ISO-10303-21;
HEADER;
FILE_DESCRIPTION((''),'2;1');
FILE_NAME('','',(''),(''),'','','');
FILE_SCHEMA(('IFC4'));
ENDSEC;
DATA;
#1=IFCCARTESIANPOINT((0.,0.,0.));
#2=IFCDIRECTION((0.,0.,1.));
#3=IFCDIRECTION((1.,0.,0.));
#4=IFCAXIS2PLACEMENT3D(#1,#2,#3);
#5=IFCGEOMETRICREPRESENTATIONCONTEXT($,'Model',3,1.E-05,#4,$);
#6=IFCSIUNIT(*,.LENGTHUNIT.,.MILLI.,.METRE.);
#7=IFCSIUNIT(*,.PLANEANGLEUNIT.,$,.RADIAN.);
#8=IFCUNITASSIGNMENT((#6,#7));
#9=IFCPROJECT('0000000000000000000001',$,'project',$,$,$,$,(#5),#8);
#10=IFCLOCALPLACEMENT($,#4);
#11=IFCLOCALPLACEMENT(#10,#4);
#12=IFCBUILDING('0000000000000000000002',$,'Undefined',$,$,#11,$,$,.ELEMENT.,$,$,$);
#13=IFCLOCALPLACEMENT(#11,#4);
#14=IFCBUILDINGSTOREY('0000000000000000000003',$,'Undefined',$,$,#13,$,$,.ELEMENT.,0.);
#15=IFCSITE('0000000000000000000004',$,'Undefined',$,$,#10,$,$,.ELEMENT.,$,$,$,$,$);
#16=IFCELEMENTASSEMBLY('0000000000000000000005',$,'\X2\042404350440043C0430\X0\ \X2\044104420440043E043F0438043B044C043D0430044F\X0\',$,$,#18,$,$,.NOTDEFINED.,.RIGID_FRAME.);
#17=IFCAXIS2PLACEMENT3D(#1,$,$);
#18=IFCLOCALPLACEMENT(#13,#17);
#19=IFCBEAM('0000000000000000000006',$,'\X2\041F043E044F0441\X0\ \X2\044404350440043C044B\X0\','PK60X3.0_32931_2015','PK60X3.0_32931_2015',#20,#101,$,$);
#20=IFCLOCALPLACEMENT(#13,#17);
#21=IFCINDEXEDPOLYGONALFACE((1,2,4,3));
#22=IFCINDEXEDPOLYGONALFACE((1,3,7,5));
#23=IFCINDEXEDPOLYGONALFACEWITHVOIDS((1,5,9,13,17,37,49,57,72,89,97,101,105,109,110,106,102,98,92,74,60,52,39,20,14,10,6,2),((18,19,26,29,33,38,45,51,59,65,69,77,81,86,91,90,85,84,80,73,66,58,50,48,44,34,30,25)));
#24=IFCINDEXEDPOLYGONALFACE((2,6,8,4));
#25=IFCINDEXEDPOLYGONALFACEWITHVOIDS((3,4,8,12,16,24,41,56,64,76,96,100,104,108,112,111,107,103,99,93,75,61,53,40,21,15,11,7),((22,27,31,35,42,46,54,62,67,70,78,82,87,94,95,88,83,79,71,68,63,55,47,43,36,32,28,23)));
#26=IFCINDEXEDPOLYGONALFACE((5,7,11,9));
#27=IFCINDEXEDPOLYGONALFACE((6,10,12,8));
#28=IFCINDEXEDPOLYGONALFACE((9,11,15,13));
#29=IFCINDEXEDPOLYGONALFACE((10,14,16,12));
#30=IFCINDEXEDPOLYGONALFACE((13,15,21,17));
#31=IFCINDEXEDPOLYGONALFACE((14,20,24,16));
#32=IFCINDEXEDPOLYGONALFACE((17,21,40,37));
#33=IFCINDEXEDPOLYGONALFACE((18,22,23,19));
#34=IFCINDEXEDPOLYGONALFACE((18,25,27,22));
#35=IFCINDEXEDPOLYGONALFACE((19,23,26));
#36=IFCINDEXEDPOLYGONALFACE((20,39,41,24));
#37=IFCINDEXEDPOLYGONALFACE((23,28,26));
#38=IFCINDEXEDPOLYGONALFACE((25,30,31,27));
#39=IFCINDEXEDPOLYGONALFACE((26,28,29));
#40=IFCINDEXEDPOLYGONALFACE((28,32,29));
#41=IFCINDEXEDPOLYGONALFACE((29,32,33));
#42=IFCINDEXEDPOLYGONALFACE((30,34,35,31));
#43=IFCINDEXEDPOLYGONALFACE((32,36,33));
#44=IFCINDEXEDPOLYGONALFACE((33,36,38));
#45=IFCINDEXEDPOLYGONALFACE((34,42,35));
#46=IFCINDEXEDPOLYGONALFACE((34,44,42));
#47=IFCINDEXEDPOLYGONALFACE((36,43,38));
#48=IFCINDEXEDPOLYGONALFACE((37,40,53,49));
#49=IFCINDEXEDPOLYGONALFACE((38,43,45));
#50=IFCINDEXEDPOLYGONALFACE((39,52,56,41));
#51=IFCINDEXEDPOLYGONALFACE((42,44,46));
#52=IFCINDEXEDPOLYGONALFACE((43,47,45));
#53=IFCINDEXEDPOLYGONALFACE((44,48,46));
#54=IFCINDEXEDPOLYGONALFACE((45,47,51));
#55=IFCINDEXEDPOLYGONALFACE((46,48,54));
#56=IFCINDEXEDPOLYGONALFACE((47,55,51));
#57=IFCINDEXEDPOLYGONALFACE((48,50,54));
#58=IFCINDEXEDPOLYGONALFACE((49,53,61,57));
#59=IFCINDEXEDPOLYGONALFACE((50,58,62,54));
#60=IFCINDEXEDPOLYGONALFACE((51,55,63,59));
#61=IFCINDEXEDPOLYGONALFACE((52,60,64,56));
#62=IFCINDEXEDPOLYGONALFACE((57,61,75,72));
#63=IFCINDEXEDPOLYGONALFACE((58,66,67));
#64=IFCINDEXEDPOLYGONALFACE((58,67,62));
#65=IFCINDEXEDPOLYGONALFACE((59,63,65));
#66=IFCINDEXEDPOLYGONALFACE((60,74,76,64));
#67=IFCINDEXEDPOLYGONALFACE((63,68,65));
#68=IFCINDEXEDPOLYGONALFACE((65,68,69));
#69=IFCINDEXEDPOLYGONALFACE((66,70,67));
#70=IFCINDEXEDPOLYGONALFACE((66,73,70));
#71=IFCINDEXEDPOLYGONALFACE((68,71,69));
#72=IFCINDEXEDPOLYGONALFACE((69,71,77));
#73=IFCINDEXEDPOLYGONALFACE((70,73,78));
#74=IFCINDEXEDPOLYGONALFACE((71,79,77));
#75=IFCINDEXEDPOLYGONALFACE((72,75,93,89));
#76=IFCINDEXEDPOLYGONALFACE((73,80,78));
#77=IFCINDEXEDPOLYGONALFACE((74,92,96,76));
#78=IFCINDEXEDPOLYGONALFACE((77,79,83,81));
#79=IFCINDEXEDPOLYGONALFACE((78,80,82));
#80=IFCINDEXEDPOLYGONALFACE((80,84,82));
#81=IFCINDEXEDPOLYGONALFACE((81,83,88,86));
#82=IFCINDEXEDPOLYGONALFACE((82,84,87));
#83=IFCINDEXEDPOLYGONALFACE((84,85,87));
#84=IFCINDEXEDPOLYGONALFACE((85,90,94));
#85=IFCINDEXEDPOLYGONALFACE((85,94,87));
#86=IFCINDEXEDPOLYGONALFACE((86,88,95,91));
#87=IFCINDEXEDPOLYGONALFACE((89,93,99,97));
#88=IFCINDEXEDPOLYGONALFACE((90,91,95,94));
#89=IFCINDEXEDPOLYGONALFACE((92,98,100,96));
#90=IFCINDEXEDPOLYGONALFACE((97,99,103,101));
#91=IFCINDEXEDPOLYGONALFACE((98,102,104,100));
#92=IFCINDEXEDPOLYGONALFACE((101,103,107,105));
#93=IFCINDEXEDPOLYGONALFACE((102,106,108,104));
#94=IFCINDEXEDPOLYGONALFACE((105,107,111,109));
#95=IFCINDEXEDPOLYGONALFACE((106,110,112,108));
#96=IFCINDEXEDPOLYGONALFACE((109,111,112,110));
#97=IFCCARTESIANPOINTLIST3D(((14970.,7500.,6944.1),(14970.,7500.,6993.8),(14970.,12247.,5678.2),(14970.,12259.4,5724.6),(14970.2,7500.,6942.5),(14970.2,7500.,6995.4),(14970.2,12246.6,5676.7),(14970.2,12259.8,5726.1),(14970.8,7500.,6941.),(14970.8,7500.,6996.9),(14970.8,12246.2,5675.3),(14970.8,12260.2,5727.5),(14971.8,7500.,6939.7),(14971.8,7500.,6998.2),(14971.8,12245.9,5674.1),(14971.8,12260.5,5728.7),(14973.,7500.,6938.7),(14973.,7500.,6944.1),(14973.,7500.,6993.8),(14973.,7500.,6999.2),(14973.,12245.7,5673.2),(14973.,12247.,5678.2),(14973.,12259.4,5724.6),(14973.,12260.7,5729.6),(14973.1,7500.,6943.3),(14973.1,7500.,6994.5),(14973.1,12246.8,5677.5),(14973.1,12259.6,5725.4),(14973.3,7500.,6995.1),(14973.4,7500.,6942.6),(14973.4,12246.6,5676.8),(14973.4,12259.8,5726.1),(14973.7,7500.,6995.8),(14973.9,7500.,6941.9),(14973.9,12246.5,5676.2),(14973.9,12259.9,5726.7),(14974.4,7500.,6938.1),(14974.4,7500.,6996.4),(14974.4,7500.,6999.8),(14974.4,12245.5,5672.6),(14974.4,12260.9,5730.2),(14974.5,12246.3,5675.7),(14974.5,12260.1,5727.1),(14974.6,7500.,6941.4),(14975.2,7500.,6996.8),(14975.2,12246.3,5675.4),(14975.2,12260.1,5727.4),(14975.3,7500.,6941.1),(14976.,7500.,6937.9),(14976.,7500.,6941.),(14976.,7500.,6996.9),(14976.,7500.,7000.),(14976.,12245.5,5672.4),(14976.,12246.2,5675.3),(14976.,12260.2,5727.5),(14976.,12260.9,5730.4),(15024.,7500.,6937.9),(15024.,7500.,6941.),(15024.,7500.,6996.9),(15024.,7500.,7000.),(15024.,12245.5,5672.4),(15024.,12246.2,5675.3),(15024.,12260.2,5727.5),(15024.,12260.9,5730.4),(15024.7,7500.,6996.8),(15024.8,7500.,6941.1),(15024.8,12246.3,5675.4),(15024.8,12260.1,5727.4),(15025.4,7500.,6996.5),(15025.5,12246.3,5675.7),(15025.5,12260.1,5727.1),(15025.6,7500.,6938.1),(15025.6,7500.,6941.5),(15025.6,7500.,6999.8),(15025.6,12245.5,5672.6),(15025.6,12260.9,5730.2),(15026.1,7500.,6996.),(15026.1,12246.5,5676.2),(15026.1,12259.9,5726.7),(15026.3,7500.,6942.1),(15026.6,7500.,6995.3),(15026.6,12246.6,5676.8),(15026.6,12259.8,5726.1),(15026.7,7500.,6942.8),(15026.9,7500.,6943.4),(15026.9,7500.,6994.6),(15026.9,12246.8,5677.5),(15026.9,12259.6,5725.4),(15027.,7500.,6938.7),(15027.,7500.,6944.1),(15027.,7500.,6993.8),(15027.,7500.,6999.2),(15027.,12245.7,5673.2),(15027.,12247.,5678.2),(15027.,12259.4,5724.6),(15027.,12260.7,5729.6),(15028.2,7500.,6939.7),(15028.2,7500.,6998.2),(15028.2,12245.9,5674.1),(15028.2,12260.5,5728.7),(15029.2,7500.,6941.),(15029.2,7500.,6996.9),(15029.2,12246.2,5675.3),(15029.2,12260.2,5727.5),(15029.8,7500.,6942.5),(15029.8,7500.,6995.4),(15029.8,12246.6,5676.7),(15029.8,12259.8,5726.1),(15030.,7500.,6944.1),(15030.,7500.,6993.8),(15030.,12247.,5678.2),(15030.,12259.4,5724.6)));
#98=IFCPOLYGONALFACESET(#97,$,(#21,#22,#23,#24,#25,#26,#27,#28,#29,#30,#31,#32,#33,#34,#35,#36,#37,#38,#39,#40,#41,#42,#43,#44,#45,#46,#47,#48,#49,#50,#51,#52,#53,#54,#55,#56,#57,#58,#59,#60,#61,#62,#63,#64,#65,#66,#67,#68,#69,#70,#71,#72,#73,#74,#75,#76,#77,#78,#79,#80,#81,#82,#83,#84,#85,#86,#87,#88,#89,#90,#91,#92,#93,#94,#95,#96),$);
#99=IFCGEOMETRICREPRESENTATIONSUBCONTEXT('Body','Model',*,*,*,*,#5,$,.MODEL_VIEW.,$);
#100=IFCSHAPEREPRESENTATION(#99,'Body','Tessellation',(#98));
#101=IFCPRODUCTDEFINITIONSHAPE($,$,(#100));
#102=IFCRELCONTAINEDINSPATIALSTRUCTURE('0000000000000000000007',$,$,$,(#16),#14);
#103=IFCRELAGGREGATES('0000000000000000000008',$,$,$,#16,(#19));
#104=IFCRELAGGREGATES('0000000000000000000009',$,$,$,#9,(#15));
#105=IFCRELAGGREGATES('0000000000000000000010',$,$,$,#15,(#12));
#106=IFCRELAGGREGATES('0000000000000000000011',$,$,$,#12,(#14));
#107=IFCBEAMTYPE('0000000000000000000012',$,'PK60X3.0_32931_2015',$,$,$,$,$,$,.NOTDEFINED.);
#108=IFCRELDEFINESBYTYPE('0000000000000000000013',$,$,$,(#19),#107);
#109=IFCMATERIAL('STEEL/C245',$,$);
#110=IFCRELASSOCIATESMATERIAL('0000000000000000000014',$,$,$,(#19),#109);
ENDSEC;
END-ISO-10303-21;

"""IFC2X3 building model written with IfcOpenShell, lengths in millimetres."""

from ifc_helpers import new_model, si_unit, frame, origin_with_axes, origin_2d_with_axis, place, context, subcontext, project, spatial, hollow_rectangle, extrude, clip, halfspace, material, type_object, element, aggregate, save


model = new_model("IFC2X3")

# Units and contexts
model_context = context("Model", 3, precision=1e-05, world=origin_with_axes())
body_context = subcontext(model_context, "Body", "Model", "MODEL_VIEW")
ifc_project = project(units=[si_unit("LENGTHUNIT", "METRE", prefix="MILLI"), si_unit("PLANEANGLEUNIT", "RADIAN")], contexts=[model_context])

# Site, building, storey
site_placement = place(None, origin_with_axes())
site = spatial("IfcSite", under=ifc_project, at=site_placement, Name="Undefined", CompositionType="ELEMENT")
building_placement = place(site_placement, origin_with_axes())
building = spatial("IfcBuilding", under=site, at=building_placement, Name="Undefined", CompositionType="ELEMENT")
storey_placement = place(building_placement, origin_with_axes())
storey = spatial("IfcBuildingStorey", under=building, at=storey_placement, Name="Undefined", CompositionType="ELEMENT", Elevation=0.0)

# Element assembly
assembly_1_placement = place(storey_placement, origin_with_axes())
assembly_1 = element("IfcElementAssembly", 1, at=assembly_1_placement, inside=storey, Name="Ферма стропильная", AssemblyPlace="NOTDEFINED", PredefinedType="RIGID_FRAME")
ifc_material_1 = material(Name="STEEL/C245")

# Beam
beam_type_1 = type_object("IfcBeamType", Name="PK60X3.0_32931_2015", PredefinedType="NOTDEFINED")
beam_1_placement = place(assembly_1_placement, frame((15000.0, 12253.2, 5701.4), z_axis=(0.0, 0.257663, 0.966235), x_axis=(0.0, -0.966235, 0.257663)))
beam_1 = element("IfcBeam", 2, at=beam_1_placement, type_object=beam_type_1, material=ifc_material_1, Name="Пояс фермы", Description="PK60X3.0_32931_2015", ObjectType="PK60X3.0_32931_2015", context=body_context, shape_type="Clipping", body=[
    clip(extrude(hollow_rectangle(XDim=60.0, YDim=60.0, WallThickness=3.0, InnerFilletRadius=3.0, OuterFilletRadius=6.0, at=origin_2d_with_axis()), frame((4942.5, 0.0, 0.0), z_axis=(-1.0, 0.0, 0.0), x_axis=(0.0, -1.0, 0.0)), (0.0, 0.0, 1.0), 4942.5), halfspace(frame((4938.1, 0.0, 70.5), z_axis=(0.966235, 0.0, -0.257663), x_axis=(0.257663, 0.0, 0.966235)), False)),
])

aggregate(assembly_1, [beam_1])

save(model, "model.ifc")
